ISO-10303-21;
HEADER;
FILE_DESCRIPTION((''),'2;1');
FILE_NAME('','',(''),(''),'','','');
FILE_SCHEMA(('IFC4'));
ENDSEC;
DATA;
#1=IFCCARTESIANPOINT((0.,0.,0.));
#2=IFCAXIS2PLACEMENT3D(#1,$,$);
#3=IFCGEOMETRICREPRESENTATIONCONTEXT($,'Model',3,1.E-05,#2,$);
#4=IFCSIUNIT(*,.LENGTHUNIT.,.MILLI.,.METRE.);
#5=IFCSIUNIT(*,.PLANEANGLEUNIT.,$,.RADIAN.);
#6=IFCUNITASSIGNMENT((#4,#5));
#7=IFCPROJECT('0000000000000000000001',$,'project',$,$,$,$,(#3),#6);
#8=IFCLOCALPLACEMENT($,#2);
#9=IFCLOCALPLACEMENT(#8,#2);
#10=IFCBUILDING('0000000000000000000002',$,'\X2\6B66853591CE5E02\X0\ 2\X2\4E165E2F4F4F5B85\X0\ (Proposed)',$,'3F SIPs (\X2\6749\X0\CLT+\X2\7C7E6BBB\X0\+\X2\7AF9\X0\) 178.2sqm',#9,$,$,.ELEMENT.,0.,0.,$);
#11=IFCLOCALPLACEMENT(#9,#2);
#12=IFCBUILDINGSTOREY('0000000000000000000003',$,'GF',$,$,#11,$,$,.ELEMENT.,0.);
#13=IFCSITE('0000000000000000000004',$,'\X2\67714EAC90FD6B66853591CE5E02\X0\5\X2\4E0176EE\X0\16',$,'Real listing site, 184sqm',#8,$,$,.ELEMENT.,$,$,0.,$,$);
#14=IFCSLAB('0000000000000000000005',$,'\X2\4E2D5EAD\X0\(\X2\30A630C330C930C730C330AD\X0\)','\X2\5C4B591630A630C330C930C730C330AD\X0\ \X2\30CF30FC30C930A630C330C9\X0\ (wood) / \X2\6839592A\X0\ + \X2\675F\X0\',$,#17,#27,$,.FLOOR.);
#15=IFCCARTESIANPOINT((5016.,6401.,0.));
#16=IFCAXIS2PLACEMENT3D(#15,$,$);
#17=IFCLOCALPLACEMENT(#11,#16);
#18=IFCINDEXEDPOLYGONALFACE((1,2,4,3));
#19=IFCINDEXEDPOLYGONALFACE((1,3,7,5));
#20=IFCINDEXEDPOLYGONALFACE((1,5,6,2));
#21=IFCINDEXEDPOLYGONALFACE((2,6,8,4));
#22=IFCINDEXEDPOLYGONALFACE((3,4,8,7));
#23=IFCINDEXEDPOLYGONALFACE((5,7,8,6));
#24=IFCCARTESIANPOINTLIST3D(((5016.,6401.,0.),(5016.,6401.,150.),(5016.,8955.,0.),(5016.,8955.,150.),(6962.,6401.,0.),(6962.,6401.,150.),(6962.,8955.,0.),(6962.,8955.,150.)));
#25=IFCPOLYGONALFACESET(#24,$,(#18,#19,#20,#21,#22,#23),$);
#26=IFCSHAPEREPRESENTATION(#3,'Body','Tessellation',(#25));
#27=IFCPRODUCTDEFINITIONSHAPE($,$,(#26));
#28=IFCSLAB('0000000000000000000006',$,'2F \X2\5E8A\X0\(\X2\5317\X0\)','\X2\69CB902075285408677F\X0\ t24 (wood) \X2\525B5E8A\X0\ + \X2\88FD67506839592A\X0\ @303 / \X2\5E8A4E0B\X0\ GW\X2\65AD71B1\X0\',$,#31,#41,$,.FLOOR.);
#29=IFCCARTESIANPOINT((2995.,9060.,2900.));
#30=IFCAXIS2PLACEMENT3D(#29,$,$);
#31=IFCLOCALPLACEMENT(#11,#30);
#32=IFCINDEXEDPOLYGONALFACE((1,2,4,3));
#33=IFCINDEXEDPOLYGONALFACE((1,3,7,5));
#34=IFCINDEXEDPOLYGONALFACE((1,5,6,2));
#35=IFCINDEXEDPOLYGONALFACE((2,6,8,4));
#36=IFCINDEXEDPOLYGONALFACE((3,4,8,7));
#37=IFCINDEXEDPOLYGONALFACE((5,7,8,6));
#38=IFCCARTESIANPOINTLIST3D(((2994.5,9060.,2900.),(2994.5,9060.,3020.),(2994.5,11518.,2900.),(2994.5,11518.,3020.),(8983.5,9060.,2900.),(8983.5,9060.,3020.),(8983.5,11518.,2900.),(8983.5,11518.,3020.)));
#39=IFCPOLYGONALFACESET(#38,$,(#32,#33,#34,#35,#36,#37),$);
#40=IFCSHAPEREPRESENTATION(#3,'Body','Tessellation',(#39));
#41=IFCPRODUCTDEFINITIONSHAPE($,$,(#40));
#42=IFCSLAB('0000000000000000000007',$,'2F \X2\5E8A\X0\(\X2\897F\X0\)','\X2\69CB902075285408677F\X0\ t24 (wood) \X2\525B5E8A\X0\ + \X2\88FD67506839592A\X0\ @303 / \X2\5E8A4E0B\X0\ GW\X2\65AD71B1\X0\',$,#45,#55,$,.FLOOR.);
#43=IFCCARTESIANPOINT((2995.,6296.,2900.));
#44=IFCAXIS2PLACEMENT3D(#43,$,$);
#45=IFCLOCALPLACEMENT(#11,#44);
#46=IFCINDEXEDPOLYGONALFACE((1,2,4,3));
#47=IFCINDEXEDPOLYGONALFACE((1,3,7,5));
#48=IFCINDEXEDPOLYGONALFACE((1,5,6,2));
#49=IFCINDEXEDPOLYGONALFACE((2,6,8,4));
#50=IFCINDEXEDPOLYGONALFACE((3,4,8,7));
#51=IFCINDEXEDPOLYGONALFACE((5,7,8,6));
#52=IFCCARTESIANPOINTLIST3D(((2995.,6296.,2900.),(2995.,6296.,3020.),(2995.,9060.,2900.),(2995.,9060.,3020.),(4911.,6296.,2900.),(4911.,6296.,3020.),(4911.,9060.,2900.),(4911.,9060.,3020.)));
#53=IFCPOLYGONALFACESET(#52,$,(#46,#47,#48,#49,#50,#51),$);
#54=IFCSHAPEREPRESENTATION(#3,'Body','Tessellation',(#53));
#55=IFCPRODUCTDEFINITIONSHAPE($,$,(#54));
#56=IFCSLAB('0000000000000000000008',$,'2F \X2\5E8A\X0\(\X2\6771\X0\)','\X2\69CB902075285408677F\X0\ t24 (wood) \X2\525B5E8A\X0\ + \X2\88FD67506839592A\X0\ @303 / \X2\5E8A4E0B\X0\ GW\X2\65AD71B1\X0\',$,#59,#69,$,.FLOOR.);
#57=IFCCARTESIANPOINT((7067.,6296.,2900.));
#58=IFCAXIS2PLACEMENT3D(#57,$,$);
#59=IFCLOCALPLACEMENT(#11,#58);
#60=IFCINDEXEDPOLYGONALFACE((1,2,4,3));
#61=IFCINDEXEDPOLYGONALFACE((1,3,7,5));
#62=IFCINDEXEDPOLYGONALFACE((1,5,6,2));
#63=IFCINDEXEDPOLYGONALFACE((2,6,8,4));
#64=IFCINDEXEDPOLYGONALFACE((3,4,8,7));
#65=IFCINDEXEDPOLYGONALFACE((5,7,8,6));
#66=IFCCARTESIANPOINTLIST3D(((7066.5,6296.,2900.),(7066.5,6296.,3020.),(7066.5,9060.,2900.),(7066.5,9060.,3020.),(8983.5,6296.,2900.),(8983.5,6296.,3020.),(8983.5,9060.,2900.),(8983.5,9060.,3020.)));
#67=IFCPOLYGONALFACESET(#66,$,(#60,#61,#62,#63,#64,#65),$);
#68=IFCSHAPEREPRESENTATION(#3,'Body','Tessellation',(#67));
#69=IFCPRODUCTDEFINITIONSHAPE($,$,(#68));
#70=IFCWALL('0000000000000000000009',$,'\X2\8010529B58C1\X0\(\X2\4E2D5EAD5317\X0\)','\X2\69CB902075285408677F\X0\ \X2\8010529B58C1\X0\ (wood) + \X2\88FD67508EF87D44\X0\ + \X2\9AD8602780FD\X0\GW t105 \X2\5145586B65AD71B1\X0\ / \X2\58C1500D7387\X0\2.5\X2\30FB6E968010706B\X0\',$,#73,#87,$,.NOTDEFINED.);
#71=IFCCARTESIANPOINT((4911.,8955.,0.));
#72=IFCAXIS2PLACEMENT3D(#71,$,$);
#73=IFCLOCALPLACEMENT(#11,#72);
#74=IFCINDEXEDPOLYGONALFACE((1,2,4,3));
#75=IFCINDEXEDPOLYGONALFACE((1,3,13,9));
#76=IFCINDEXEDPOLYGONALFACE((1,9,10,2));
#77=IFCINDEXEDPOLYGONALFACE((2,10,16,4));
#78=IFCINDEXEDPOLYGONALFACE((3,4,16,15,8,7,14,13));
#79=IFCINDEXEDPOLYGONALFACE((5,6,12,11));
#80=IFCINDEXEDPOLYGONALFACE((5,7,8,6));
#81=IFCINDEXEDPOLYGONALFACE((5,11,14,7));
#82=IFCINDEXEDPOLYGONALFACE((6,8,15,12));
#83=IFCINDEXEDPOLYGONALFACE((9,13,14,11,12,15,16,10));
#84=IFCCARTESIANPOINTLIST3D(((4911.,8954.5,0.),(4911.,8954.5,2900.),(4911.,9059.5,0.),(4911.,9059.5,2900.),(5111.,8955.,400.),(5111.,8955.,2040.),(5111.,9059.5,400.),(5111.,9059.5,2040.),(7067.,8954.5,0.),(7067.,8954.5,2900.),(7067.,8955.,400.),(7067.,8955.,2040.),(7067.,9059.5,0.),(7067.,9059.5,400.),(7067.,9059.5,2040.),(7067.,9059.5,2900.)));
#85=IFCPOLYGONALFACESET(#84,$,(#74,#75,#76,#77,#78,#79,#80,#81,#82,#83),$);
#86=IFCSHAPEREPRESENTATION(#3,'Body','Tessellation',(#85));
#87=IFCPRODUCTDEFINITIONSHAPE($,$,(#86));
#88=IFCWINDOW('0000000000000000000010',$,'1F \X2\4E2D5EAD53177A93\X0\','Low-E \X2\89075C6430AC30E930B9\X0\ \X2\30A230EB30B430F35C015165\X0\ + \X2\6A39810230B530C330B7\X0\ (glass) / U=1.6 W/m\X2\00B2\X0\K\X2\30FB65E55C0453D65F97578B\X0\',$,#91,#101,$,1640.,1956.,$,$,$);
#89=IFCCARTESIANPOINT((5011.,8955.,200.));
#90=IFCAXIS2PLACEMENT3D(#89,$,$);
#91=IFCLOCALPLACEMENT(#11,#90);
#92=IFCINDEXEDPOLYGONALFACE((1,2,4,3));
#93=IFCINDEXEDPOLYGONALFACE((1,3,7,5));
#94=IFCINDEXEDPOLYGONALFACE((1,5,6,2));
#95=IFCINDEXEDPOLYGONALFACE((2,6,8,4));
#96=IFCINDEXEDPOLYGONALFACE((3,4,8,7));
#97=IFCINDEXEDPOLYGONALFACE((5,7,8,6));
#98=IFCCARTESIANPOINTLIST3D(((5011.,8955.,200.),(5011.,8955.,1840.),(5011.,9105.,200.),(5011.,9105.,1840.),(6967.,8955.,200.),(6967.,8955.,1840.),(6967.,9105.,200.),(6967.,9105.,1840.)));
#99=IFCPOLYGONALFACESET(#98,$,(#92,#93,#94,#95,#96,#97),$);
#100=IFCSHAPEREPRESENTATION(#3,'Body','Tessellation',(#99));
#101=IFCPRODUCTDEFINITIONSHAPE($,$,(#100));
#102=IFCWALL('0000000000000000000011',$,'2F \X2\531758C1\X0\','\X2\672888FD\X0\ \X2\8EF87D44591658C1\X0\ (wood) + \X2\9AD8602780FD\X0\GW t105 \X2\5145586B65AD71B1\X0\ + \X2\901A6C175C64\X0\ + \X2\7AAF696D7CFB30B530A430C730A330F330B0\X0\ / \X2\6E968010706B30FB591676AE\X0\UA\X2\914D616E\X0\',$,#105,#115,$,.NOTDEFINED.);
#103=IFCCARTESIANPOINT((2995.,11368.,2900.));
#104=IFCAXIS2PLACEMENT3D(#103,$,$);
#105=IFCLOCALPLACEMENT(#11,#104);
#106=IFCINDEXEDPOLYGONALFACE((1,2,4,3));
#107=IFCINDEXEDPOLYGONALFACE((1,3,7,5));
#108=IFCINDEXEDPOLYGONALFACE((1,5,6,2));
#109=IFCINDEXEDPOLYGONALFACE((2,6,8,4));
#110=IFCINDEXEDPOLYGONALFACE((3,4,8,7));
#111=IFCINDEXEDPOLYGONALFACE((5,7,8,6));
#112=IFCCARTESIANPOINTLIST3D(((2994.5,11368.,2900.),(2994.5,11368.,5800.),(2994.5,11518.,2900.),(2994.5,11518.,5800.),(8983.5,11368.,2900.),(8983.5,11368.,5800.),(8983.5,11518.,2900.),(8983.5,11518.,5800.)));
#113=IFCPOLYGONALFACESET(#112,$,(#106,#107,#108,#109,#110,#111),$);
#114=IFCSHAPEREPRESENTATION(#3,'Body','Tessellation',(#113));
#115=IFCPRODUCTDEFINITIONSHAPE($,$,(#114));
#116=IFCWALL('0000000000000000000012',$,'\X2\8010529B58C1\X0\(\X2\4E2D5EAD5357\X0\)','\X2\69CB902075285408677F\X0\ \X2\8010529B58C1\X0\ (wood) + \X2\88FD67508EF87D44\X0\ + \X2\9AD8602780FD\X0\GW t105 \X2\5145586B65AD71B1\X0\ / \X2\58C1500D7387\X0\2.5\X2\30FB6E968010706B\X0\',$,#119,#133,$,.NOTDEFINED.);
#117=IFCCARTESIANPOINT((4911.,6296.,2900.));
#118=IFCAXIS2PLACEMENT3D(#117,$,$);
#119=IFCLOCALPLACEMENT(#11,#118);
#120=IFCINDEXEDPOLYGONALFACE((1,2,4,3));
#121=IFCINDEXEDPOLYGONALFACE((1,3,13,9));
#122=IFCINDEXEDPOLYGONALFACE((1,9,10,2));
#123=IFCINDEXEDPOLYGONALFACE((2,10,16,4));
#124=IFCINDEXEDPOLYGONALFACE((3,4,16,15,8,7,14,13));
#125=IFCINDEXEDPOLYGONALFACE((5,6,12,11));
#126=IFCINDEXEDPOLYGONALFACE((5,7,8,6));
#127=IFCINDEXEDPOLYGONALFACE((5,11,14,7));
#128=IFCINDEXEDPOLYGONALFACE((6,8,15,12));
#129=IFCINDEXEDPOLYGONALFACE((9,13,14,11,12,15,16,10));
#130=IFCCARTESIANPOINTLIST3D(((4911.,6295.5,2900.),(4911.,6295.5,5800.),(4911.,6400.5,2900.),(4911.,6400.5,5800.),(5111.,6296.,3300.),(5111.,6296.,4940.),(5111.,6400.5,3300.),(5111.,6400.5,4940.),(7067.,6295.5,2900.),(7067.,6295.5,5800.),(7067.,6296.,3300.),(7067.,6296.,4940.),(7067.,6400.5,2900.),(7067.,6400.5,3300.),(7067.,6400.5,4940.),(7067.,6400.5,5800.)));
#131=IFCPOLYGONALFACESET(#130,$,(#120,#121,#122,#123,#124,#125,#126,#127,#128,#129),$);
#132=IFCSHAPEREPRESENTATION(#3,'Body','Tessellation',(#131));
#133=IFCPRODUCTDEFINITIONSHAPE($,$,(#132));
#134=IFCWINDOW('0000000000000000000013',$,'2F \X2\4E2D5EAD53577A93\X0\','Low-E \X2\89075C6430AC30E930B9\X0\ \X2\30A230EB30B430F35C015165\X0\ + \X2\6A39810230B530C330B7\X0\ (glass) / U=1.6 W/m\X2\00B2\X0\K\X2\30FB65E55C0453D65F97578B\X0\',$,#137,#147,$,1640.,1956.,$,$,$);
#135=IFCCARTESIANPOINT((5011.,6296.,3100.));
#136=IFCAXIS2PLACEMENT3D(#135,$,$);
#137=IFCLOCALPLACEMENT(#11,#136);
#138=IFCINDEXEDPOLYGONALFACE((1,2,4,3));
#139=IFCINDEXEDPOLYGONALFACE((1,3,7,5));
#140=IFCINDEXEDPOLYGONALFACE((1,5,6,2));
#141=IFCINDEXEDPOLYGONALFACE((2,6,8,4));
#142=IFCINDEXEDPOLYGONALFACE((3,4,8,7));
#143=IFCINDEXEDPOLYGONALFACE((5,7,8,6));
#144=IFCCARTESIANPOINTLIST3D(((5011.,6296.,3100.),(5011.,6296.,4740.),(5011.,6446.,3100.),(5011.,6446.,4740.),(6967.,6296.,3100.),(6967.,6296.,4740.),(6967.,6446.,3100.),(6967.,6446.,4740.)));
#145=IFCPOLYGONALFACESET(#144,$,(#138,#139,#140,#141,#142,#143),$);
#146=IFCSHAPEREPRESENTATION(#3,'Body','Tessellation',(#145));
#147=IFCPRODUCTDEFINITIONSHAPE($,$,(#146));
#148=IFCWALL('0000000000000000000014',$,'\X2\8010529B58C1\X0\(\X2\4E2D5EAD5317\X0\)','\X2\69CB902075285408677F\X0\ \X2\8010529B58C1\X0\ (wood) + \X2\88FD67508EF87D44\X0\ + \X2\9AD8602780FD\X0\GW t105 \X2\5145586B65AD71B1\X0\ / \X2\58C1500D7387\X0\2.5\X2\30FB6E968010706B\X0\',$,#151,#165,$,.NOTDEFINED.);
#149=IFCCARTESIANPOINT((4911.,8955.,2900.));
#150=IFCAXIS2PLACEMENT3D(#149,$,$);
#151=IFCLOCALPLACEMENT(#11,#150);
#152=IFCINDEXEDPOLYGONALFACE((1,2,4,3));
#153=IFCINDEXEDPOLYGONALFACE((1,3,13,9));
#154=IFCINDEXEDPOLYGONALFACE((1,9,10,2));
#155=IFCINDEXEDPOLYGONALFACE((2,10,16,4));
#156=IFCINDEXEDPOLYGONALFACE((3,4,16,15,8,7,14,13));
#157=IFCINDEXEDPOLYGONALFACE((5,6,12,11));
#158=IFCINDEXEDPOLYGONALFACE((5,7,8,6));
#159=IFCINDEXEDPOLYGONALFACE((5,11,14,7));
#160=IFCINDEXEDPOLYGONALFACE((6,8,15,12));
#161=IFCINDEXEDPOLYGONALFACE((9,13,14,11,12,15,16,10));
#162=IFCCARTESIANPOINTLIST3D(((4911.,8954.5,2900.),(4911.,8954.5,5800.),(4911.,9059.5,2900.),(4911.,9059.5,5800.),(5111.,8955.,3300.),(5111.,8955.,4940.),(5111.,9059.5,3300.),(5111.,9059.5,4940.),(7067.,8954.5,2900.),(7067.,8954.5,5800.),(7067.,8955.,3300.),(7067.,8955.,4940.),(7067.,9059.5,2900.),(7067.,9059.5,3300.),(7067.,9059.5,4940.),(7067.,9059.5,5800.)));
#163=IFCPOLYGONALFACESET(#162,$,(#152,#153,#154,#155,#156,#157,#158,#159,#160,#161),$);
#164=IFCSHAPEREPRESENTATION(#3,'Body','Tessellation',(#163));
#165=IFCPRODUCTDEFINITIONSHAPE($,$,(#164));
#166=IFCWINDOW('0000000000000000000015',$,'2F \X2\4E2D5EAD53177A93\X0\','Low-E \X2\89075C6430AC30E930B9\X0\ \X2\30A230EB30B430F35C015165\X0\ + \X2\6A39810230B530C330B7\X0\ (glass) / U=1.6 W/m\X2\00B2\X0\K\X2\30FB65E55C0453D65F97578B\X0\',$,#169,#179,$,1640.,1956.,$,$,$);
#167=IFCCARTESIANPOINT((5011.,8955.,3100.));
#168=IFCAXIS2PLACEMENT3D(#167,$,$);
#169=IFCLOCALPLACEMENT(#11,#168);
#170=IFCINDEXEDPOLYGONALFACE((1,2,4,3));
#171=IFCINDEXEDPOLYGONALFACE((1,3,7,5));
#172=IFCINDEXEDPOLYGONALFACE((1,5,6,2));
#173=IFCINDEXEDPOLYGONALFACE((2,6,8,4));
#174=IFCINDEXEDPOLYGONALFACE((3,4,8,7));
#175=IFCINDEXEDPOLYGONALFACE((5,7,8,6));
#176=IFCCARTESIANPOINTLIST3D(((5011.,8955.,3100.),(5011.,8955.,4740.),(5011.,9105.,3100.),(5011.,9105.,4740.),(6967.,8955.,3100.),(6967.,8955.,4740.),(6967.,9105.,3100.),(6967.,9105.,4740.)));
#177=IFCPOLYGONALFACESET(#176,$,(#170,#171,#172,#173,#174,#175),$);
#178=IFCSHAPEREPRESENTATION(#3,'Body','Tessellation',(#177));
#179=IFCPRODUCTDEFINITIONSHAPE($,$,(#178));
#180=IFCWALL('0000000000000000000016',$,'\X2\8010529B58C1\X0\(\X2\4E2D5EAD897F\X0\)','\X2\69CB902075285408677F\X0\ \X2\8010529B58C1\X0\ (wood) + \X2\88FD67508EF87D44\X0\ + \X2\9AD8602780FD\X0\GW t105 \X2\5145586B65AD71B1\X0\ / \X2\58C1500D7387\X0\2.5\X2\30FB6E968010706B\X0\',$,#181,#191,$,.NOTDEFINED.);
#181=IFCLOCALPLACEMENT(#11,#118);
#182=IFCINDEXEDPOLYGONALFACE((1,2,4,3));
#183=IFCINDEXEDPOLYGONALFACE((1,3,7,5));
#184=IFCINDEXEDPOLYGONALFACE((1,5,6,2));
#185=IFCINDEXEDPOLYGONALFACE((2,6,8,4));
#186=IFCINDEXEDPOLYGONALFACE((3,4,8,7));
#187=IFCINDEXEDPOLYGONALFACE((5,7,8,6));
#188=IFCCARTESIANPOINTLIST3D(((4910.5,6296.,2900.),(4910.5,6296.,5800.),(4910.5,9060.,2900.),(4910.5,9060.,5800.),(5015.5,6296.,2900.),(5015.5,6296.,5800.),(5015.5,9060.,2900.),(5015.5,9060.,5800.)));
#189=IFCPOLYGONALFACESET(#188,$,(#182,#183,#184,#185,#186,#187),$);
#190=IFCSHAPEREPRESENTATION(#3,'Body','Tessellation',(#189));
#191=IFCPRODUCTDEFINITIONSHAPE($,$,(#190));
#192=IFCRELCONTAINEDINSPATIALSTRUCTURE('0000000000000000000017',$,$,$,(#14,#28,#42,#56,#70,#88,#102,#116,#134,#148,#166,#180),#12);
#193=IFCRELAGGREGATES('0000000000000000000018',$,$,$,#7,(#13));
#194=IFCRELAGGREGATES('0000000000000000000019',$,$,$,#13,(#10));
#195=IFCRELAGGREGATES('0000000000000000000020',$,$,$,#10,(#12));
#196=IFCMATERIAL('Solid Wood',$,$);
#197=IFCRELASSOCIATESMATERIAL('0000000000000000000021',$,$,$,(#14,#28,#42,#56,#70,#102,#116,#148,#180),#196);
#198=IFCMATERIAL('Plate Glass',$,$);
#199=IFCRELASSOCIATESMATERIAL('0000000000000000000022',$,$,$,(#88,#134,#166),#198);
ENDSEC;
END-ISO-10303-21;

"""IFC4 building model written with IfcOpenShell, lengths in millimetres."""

from ifc_helpers import new_model, si_unit, frame, frame_2d, origin, place, context, project, spatial, rectangle, extrude, material, element, fill, save


model = new_model("IFC4")

# Units and contexts
model_context = context("Model", 3, precision=1e-05, world=origin())
ifc_project = project(units=[si_unit("LENGTHUNIT", "METRE", prefix="MILLI"), si_unit("PLANEANGLEUNIT", "RADIAN")], contexts=[model_context])

# Site, building, storey
site_placement = place(None, origin())
site = spatial("IfcSite", under=ifc_project, at=site_placement, Name="東京都武蔵野市5丁目16", ObjectType="Real listing site, 184sqm", CompositionType="ELEMENT", RefElevation=0.0)
building_placement = place(site_placement, origin())
building = spatial("IfcBuilding", under=site, at=building_placement, Name="武蔵野市 2世帯住宅 (Proposed)", ObjectType="3F SIPs (杉CLT+籾殻+竹) 178.2sqm", CompositionType="ELEMENT", ElevationOfRefHeight=0.0, ElevationOfTerrain=0.0)
storey_placement = place(building_placement, origin())
storey = spatial("IfcBuildingStorey", under=building, at=storey_placement, Name="GF", CompositionType="ELEMENT", Elevation=0.0)

# Slabs
ifc_material_1 = material(Name="Solid Wood")
slab_1_placement = place(storey_placement, frame((5016.0, 6401.0, 0.0)))
element("IfcSlab", 1, at=slab_1_placement, inside=storey, material=ifc_material_1, Name="中庭(ウッドデッキ)", Description="屋外ウッドデッキ ハードウッド (wood) / 根太 + 束", PredefinedType="FLOOR", context=model_context, shape_type="SweptSolid", body=[
    extrude(rectangle(XDim=1946.0, YDim=2554.0, at=frame_2d((973.0, 1277.0))), frame((5016.0, 6401.0, 0.0)), (0.0, 0.0, 1.0), 150.0),
])
slab_2_placement = place(storey_placement, frame((2995.0, 9060.0, 2900.0)))
element("IfcSlab", 2, at=slab_2_placement, inside=storey, material=ifc_material_1, Name="2F 床(北)", Description="構造用合板 t24 (wood) 剛床 + 製材根太 @303 / 床下 GW断熱", PredefinedType="FLOOR", context=model_context, shape_type="SweptSolid", body=[
    extrude(rectangle(XDim=5989.0, YDim=2458.0, at=frame_2d((2994.0, 1229.0))), frame((2995.0, 9060.0, 2900.0)), (0.0, 0.0, 1.0), 120.0),
])
slab_3_placement = place(storey_placement, frame((2995.0, 6296.0, 2900.0)))
element("IfcSlab", 3, at=slab_3_placement, inside=storey, material=ifc_material_1, Name="2F 床(西)", Description="構造用合板 t24 (wood) 剛床 + 製材根太 @303 / 床下 GW断熱", PredefinedType="FLOOR", context=model_context, shape_type="SweptSolid", body=[
    extrude(rectangle(XDim=1916.0, YDim=2764.0, at=frame_2d((958.0, 1382.0))), frame((2995.0, 6296.0, 2900.0)), (0.0, 0.0, 1.0), 120.0),
])
slab_4_placement = place(storey_placement, frame((7067.0, 6296.0, 2900.0)))
element("IfcSlab", 4, at=slab_4_placement, inside=storey, material=ifc_material_1, Name="2F 床(東)", Description="構造用合板 t24 (wood) 剛床 + 製材根太 @303 / 床下 GW断熱", PredefinedType="FLOOR", context=model_context, shape_type="SweptSolid", body=[
    extrude(rectangle(XDim=1917.0, YDim=2764.0, at=frame_2d((958.0, 1382.0))), frame((7067.0, 6296.0, 2900.0)), (0.0, 0.0, 1.0), 120.0),
])

# Wall, opening, window
wall_1_placement = place(storey_placement, frame((4911.0, 8955.0, 0.0)))
wall_1 = element("IfcWall", 5, at=wall_1_placement, inside=storey, material=ifc_material_1, Name="耐力壁(中庭北)", Description="構造用合板 耐力壁 (wood) + 製材軸組 + 高性能GW t105 充填断熱 / 壁倍率2.5・準耐火", PredefinedType="NOTDEFINED", context=model_context, shape_type="SweptSolid", body=[
    extrude(rectangle(XDim=2156.0, YDim=105.0, at=frame_2d((1078.0, 52.0))), frame((4911.0, 8955.0, 0.0)), (0.0, 0.0, 1.0), 2900.0),
])
opening_1_placement = place(storey_placement, frame((5011.0, 8955.0, 200.0)))
opening_1 = element("IfcOpeningElement", 6, at=opening_1_placement, cuts=wall_1, PredefinedType="NOTDEFINED", context=model_context, shape_type="SweptSolid", body=[
    extrude(rectangle(XDim=1956.0, YDim=150.0, at=frame_2d((978.0, 75.0))), frame((5011.0, 8955.0, 200.0)), (0.0, 0.0, 1.0), 1640.0),
])
ifc_material_2 = material(Name="Plate Glass")
window_1_placement = place(storey_placement, frame((5011.0, 8955.0, 200.0)))
window_1 = element("IfcWindow", 7, at=window_1_placement, inside=storey, material=ifc_material_2, Name="1F 中庭北窓", Description="Low-E 複層ガラス アルゴン封入 + 樹脂サッシ (glass) / U=1.6 W/m²K・日射取得型", OverallHeight=1640.0, OverallWidth=1956.0, context=model_context, shape_type="SweptSolid", body=[
    extrude(rectangle(XDim=1956.0, YDim=150.0, at=frame_2d((978.0, 75.0))), frame((5011.0, 8955.0, 200.0)), (0.0, 0.0, 1.0), 1640.0),
])
fill(opening_1, window_1)

# Wall
wall_2_placement = place(storey_placement, frame((2995.0, 11368.0, 2900.0)))
element("IfcWall", 8, at=wall_2_placement, inside=storey, material=ifc_material_1, Name="2F 北壁", Description="木製 軸組外壁 (wood) + 高性能GW t105 充填断熱 + 通気層 + 窯業系サイディング / 準耐火・外皮UA配慮", PredefinedType="NOTDEFINED", context=model_context, shape_type="SweptSolid", body=[
    extrude(rectangle(XDim=5989.0, YDim=150.0, at=frame_2d((2994.0, 75.0))), frame((2995.0, 11368.0, 2900.0)), (0.0, 0.0, 1.0), 2900.0),
])

# Walls, openings, windows
wall_3_placement = place(storey_placement, frame((4911.0, 6296.0, 2900.0)))
wall_3 = element("IfcWall", 9, at=wall_3_placement, inside=storey, material=ifc_material_1, Name="耐力壁(中庭南)", Description="構造用合板 耐力壁 (wood) + 製材軸組 + 高性能GW t105 充填断熱 / 壁倍率2.5・準耐火", PredefinedType="NOTDEFINED", context=model_context, shape_type="SweptSolid", body=[
    extrude(rectangle(XDim=2156.0, YDim=105.0, at=frame_2d((1078.0, 52.0))), frame((4911.0, 6296.0, 2900.0)), (0.0, 0.0, 1.0), 2900.0),
])
opening_2_placement = place(storey_placement, frame((5011.0, 6296.0, 3100.0)))
opening_2 = element("IfcOpeningElement", 10, at=opening_2_placement, cuts=wall_3, PredefinedType="NOTDEFINED", context=model_context, shape_type="SweptSolid", body=[
    extrude(rectangle(XDim=1956.0, YDim=150.0, at=frame_2d((978.0, 75.0))), frame((5011.0, 6296.0, 3100.0)), (0.0, 0.0, 1.0), 1640.0),
])
window_2_placement = place(storey_placement, frame((5011.0, 6296.0, 3100.0)))
window_2 = element("IfcWindow", 11, at=window_2_placement, inside=storey, material=ifc_material_2, Name="2F 中庭南窓", Description="Low-E 複層ガラス アルゴン封入 + 樹脂サッシ (glass) / U=1.6 W/m²K・日射取得型", OverallHeight=1640.0, OverallWidth=1956.0, context=model_context, shape_type="SweptSolid", body=[
    extrude(rectangle(XDim=1956.0, YDim=150.0, at=frame_2d((978.0, 75.0))), frame((5011.0, 6296.0, 3100.0)), (0.0, 0.0, 1.0), 1640.0),
])
fill(opening_2, window_2)
wall_4_placement = place(storey_placement, frame((4911.0, 8955.0, 2900.0)))
wall_4 = element("IfcWall", 12, at=wall_4_placement, inside=storey, material=ifc_material_1, Name="耐力壁(中庭北)", Description="構造用合板 耐力壁 (wood) + 製材軸組 + 高性能GW t105 充填断熱 / 壁倍率2.5・準耐火", PredefinedType="NOTDEFINED", context=model_context, shape_type="SweptSolid", body=[
    extrude(rectangle(XDim=2156.0, YDim=105.0, at=frame_2d((1078.0, 52.0))), frame((4911.0, 8955.0, 2900.0)), (0.0, 0.0, 1.0), 2900.0),
])
opening_3_placement = place(storey_placement, frame((5011.0, 8955.0, 3100.0)))
opening_3 = element("IfcOpeningElement", 13, at=opening_3_placement, cuts=wall_4, PredefinedType="NOTDEFINED", context=model_context, shape_type="SweptSolid", body=[
    extrude(rectangle(XDim=1956.0, YDim=150.0, at=frame_2d((978.0, 75.0))), frame((5011.0, 8955.0, 3100.0)), (0.0, 0.0, 1.0), 1640.0),
])
window_3_placement = place(storey_placement, frame((5011.0, 8955.0, 3100.0)))
window_3 = element("IfcWindow", 14, at=window_3_placement, inside=storey, material=ifc_material_2, Name="2F 中庭北窓", Description="Low-E 複層ガラス アルゴン封入 + 樹脂サッシ (glass) / U=1.6 W/m²K・日射取得型", OverallHeight=1640.0, OverallWidth=1956.0, context=model_context, shape_type="SweptSolid", body=[
    extrude(rectangle(XDim=1956.0, YDim=150.0, at=frame_2d((978.0, 75.0))), frame((5011.0, 8955.0, 3100.0)), (0.0, 0.0, 1.0), 1640.0),
])
fill(opening_3, window_3)

# Wall
wall_5_placement = place(storey_placement, frame((4911.0, 6296.0, 2900.0)))
element("IfcWall", 15, at=wall_5_placement, inside=storey, material=ifc_material_1, Name="耐力壁(中庭西)", Description="構造用合板 耐力壁 (wood) + 製材軸組 + 高性能GW t105 充填断熱 / 壁倍率2.5・準耐火", PredefinedType="NOTDEFINED", context=model_context, shape_type="SweptSolid", body=[
    extrude(rectangle(XDim=105.0, YDim=2764.0, at=frame_2d((52.0, 1382.0))), frame((4911.0, 6296.0, 2900.0)), (0.0, 0.0, 1.0), 2900.0),
])

save(model, "model.ifc")
